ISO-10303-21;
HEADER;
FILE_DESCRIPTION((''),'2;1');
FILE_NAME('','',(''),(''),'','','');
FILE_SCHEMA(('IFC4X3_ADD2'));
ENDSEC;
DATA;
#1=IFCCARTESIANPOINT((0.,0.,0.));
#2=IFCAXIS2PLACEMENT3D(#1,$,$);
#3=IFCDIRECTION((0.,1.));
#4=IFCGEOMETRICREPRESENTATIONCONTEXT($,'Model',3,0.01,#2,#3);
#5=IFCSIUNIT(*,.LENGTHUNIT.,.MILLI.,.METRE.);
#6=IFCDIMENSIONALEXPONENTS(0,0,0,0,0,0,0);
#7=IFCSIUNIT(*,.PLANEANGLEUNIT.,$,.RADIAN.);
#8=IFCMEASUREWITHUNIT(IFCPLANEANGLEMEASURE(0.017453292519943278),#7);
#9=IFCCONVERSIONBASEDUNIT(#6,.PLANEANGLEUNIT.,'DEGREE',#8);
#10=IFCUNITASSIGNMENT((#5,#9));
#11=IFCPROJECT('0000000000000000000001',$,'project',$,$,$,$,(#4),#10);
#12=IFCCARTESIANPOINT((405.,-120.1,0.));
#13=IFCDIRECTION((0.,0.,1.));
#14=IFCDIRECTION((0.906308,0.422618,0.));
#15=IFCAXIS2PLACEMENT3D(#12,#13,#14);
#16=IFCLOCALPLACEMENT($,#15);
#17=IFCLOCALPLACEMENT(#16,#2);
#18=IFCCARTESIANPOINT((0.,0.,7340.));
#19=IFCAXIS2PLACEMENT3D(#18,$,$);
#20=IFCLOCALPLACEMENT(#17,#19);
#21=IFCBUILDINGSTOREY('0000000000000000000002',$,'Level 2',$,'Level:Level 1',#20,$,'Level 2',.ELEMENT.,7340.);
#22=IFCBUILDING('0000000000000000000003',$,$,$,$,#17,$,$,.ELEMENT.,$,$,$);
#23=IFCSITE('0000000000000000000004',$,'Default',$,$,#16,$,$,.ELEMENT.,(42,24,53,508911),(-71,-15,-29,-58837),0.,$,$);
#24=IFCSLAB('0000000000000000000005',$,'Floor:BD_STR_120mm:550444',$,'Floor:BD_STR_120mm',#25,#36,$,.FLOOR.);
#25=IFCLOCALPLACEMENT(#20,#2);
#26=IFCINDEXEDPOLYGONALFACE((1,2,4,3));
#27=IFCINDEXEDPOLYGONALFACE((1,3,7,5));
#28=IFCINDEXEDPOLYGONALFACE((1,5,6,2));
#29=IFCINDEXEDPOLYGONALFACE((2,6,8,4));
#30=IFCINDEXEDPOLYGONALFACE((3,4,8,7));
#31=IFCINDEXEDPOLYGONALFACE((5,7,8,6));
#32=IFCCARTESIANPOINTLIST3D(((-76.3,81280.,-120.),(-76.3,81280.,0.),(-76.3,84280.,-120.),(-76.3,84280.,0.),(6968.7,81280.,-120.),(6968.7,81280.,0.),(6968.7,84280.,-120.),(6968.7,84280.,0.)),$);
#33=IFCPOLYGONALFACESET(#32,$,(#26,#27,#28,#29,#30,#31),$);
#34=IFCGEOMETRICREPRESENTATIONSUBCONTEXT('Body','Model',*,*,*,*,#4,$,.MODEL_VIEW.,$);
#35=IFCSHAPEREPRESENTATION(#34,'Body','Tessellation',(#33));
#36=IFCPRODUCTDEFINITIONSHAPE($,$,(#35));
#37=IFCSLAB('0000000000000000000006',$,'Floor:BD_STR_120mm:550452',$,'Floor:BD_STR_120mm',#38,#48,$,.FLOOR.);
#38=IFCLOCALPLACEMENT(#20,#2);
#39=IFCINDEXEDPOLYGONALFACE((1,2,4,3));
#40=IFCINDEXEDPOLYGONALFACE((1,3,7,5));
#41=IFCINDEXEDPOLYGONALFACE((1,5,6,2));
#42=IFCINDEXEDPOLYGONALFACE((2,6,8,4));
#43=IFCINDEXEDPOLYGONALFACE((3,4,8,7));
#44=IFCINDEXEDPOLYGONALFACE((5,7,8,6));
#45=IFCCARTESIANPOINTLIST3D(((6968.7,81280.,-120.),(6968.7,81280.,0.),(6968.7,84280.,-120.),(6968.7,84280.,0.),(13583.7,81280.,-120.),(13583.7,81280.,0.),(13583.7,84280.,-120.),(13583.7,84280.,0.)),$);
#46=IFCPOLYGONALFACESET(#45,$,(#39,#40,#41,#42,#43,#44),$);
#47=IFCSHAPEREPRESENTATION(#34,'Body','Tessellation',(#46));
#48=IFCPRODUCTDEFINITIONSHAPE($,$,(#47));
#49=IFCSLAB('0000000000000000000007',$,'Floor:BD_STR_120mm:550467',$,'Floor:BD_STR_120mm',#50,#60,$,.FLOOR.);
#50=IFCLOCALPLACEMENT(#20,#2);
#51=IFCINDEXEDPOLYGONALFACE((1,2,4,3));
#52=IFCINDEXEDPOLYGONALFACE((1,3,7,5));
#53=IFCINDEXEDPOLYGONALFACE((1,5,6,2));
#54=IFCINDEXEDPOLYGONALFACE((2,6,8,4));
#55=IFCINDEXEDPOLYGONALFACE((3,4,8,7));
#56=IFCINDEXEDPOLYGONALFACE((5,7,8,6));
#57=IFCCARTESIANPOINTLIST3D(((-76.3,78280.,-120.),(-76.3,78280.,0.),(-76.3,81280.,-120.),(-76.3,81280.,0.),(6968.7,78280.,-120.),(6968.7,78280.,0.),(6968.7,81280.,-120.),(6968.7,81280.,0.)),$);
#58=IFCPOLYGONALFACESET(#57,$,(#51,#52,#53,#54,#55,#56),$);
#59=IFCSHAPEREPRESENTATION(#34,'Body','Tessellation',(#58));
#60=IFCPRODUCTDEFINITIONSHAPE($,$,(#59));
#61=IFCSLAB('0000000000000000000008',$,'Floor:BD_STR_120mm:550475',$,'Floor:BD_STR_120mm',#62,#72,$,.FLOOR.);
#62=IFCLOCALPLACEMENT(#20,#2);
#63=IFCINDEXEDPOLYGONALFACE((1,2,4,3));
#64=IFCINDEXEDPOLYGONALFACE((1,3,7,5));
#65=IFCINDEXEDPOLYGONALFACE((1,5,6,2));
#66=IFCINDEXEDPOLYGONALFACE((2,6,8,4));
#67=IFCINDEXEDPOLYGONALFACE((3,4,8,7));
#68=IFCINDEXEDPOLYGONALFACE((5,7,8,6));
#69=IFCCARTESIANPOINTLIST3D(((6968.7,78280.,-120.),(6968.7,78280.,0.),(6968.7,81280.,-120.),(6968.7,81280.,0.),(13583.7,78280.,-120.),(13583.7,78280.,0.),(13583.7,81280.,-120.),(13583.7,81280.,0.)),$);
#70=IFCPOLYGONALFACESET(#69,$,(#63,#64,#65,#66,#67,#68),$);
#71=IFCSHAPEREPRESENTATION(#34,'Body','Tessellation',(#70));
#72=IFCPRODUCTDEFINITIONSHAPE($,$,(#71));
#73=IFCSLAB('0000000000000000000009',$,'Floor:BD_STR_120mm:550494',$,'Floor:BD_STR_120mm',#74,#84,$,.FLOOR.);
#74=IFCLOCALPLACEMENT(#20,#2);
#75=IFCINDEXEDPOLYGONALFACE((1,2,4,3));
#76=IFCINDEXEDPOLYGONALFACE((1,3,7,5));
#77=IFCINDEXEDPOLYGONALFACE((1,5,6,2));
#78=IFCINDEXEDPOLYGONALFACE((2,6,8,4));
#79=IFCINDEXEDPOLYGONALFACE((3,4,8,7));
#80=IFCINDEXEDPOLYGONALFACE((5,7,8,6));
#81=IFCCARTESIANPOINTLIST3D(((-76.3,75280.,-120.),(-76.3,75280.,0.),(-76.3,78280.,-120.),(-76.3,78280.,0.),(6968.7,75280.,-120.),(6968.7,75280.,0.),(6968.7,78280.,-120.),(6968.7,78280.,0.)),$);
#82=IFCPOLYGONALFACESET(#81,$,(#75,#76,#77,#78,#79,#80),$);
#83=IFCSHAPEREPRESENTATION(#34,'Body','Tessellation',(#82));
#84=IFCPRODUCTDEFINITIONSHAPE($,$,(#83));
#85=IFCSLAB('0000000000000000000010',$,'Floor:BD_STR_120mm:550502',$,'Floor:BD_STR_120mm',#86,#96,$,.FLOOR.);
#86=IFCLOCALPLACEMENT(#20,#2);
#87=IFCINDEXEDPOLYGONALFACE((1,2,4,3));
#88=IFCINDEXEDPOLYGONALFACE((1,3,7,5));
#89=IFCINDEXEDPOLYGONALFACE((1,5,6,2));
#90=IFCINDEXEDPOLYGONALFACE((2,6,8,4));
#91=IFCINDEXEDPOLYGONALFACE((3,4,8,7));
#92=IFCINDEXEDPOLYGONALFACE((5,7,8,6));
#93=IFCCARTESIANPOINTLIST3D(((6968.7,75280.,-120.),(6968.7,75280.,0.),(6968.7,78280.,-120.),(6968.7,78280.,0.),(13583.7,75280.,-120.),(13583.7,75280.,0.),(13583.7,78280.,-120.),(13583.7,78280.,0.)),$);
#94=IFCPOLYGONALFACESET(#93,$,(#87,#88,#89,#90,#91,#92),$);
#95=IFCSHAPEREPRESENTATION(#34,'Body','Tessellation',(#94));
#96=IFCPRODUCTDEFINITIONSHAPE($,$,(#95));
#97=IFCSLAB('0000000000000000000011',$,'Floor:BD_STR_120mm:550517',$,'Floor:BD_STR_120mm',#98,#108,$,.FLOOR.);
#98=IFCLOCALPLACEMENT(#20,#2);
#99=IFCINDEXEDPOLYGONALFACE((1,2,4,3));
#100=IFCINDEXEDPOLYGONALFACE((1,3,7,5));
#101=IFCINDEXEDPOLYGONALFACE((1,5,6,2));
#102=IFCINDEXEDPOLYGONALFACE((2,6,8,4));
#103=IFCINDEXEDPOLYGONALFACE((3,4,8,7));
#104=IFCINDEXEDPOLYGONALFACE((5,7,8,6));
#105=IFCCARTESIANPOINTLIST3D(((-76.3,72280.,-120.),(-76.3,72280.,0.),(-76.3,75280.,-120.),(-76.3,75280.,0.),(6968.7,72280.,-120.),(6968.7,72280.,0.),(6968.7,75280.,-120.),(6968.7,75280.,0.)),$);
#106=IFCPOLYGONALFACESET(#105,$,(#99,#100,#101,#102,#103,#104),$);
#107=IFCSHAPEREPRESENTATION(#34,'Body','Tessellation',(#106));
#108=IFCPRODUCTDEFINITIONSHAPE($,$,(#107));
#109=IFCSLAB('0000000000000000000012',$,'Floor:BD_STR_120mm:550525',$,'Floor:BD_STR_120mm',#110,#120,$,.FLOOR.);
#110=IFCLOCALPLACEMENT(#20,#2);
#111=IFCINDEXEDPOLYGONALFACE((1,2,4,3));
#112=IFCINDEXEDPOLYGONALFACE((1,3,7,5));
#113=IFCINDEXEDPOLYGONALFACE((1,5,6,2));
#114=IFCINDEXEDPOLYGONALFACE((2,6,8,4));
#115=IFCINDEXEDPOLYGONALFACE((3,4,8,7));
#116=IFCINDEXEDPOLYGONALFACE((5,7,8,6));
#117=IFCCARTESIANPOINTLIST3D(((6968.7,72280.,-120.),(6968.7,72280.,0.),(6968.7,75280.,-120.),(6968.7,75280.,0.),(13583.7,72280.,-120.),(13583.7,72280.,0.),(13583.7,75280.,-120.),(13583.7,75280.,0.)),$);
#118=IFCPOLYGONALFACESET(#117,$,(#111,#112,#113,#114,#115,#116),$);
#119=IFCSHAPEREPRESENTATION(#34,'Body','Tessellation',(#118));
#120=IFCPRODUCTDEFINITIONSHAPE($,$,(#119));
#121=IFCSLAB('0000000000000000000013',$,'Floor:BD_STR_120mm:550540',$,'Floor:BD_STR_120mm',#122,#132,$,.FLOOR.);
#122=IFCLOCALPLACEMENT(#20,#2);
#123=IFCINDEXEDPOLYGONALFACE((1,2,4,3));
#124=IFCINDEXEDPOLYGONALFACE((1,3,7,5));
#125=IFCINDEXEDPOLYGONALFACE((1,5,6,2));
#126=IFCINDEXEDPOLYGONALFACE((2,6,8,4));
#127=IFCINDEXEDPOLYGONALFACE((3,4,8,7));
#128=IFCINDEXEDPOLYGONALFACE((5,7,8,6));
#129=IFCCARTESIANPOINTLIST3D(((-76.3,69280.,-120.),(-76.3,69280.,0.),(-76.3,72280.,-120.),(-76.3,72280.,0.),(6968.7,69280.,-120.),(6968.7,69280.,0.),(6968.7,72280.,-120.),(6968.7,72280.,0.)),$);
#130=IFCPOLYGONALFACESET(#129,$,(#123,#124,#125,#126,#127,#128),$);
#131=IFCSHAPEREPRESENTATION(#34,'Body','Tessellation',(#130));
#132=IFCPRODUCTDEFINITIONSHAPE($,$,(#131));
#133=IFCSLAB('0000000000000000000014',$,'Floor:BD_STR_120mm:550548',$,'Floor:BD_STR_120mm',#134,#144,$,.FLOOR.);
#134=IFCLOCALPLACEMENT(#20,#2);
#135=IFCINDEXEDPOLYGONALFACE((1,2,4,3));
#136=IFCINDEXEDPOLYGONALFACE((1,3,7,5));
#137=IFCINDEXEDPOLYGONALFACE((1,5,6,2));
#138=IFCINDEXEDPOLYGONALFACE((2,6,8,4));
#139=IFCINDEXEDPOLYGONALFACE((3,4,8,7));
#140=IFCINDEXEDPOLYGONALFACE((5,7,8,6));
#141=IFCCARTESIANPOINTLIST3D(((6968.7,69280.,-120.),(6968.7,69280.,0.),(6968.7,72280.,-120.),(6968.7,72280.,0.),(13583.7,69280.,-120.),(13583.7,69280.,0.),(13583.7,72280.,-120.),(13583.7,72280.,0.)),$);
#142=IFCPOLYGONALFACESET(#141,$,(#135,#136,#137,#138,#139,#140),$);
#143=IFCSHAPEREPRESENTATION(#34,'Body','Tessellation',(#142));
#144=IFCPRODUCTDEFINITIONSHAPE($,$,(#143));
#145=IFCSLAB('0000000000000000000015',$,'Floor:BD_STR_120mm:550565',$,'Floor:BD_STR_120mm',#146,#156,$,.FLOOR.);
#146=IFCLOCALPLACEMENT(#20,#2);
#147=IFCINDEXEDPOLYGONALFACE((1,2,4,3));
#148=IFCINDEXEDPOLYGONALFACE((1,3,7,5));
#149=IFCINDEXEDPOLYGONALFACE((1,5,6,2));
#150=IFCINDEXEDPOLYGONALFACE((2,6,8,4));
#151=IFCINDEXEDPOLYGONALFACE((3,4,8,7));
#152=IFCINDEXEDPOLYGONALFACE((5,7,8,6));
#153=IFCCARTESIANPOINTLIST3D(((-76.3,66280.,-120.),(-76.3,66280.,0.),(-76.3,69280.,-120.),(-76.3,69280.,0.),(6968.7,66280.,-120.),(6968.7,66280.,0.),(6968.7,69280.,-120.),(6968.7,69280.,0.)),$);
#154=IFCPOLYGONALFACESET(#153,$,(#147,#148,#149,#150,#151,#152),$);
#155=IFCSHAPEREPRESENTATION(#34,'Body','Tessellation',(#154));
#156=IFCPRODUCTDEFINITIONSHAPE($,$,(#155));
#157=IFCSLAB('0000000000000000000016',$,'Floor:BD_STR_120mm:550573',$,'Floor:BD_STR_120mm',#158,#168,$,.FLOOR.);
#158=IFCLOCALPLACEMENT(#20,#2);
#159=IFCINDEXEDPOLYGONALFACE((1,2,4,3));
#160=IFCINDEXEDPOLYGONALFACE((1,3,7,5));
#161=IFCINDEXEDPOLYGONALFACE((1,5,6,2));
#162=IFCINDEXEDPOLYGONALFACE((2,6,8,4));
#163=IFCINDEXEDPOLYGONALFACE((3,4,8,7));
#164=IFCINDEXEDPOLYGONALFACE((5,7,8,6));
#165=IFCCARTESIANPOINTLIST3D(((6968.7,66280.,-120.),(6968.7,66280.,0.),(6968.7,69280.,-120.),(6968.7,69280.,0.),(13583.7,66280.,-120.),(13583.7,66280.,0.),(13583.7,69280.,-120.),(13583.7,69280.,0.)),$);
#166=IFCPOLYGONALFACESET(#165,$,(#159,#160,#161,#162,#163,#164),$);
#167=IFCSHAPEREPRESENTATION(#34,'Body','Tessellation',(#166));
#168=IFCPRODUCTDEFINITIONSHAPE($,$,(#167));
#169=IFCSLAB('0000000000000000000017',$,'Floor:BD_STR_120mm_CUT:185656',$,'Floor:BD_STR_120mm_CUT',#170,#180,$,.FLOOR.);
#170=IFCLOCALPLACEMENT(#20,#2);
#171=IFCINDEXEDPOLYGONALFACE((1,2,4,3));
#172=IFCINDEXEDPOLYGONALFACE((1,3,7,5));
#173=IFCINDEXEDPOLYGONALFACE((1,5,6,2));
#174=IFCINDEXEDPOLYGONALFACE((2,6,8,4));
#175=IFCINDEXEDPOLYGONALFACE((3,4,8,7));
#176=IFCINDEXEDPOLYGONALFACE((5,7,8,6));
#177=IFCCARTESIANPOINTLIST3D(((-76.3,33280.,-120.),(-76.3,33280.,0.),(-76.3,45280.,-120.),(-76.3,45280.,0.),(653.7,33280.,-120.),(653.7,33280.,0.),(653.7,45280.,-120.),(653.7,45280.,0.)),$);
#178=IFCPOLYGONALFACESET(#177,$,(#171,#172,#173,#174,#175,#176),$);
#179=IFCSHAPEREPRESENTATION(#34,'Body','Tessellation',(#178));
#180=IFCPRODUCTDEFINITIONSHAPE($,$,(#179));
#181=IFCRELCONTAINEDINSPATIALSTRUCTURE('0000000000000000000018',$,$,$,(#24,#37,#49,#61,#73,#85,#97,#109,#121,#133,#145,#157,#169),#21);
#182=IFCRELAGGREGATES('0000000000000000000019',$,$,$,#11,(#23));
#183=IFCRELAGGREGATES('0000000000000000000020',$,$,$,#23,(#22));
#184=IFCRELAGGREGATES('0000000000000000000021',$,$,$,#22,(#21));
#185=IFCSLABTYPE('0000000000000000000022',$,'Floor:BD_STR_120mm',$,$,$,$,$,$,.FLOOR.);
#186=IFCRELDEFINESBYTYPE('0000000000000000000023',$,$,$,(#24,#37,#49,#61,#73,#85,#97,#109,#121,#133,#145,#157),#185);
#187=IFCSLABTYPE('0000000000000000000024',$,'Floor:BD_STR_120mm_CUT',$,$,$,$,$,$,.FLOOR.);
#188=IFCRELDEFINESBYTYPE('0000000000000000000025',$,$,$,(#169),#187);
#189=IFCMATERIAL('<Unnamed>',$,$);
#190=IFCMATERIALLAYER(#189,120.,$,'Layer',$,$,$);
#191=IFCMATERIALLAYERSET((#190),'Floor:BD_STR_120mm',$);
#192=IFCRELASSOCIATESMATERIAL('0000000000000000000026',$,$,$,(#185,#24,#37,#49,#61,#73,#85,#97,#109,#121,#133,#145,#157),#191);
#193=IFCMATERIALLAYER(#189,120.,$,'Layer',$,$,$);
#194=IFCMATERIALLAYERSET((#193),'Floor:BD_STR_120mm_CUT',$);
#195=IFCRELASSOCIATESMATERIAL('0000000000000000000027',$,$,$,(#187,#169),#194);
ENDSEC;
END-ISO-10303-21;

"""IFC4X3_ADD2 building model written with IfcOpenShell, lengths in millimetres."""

from ifc_helpers import new_model, entity, si_unit, converted_unit, direction, frame, frame_2d, origin, origin_2d_with_axis, place, context, subcontext, project, spatial, rectangle, extrude, material, layer, layer_set, layer_usage, type_object, element, save


model = new_model("IFC4X3_ADD2")

# Units and contexts
model_context = context("Model", 3, precision=0.01, world=origin(), true_north=direction((0.0, 1.0)))
body_context = subcontext(model_context, "Body", "Model", "MODEL_VIEW")
ifc_project = project(units=[si_unit("LENGTHUNIT", "METRE", prefix="MILLI"), converted_unit("PLANEANGLEUNIT", "DEGREE", entity("IfcPlaneAngleMeasure", 0.017453292519943278), si_unit("PLANEANGLEUNIT", "RADIAN"), dimensions=[0, 0, 0, 0, 0, 0, 0])], contexts=[model_context])

# Site, building, storey
site_placement = place(None, frame((405.0, -120.1, 0.0), z_axis=(0.0, 0.0, 1.0), x_axis=(0.906308, 0.422618, 0.0)))
site = spatial("IfcSite", under=ifc_project, at=site_placement, Name="Default", CompositionType="ELEMENT", RefLatitude=(42, 24, 53, 508911), RefLongitude=(-71, -15, -29, -58837), RefElevation=0.0)
building_placement = place(site_placement, origin())
building = spatial("IfcBuilding", under=site, at=building_placement, CompositionType="ELEMENT")
storey_placement = place(building_placement, frame((0.0, 0.0, 7340.0)))
storey = spatial("IfcBuildingStorey", under=building, at=storey_placement, Name="Level 2", ObjectType="Level:Level 1", LongName="Level 2", CompositionType="ELEMENT", Elevation=7340.0)

# Slabs
ifc_material_1 = material(Name="<Unnamed>")
ifc_layer_1 = layer(ifc_material_1, 120.0, Name="Layer")
ifc_layer_set_1 = layer_set([ifc_layer_1], Name="Floor:BD_STR_120mm")
slab_type_1 = type_object("IfcSlabType", Name="Floor:BD_STR_120mm", PredefinedType="FLOOR", material=ifc_layer_set_1)
ifc_layer_usage_1 = layer_usage(ifc_layer_set_1, "AXIS3", "POSITIVE", 0.0)
slab_1_placement = place(storey_placement, origin())
element("IfcSlab", 1, at=slab_1_placement, inside=storey, type_object=slab_type_1, material=ifc_layer_usage_1, Name="Floor:BD_STR_120mm:550444", ObjectType="Floor:BD_STR_120mm", PredefinedType="FLOOR", context=body_context, shape_type="SweptSolid", body=[
    extrude(rectangle(XDim=3000.0, YDim=7045.0, at=origin_2d_with_axis()), frame((3446.2, 82780.0, 0.0), z_axis=(0.0, 0.0, -1.0), x_axis=(0.0, 1.0, 0.0)), (0.0, 0.0, 1.0), 120.0),
])
ifc_layer_usage_2 = layer_usage(ifc_layer_set_1, "AXIS3", "POSITIVE", 0.0)
slab_2_placement = place(storey_placement, origin())
element("IfcSlab", 2, at=slab_2_placement, inside=storey, type_object=slab_type_1, material=ifc_layer_usage_2, Name="Floor:BD_STR_120mm:550452", ObjectType="Floor:BD_STR_120mm", PredefinedType="FLOOR", context=body_context, shape_type="SweptSolid", body=[
    extrude(rectangle(XDim=3000.0, YDim=6615.0, at=frame_2d((0.0, 0.0), x_axis=(1.0, 0.0))), frame((10276.2, 82780.0, 0.0), z_axis=(0.0, 0.0, -1.0), x_axis=(0.0, 1.0, 0.0)), (0.0, 0.0, 1.0), 120.0),
])
ifc_layer_usage_3 = layer_usage(ifc_layer_set_1, "AXIS3", "POSITIVE", 0.0)
slab_3_placement = place(storey_placement, origin())
element("IfcSlab", 3, at=slab_3_placement, inside=storey, type_object=slab_type_1, material=ifc_layer_usage_3, Name="Floor:BD_STR_120mm:550467", ObjectType="Floor:BD_STR_120mm", PredefinedType="FLOOR", context=body_context, shape_type="SweptSolid", body=[
    extrude(rectangle(XDim=3000.0, YDim=7045.0, at=origin_2d_with_axis()), frame((3446.2, 79780.0, 0.0), z_axis=(0.0, 0.0, -1.0), x_axis=(0.0, 1.0, 0.0)), (0.0, 0.0, 1.0), 120.0),
])
ifc_layer_usage_4 = layer_usage(ifc_layer_set_1, "AXIS3", "POSITIVE", 0.0)
slab_4_placement = place(storey_placement, origin())
element("IfcSlab", 4, at=slab_4_placement, inside=storey, type_object=slab_type_1, material=ifc_layer_usage_4, Name="Floor:BD_STR_120mm:550475", ObjectType="Floor:BD_STR_120mm", PredefinedType="FLOOR", context=body_context, shape_type="SweptSolid", body=[
    extrude(rectangle(XDim=3000.0, YDim=6615.0, at=frame_2d((0.0, 0.0), x_axis=(1.0, 0.0))), frame((10276.2, 79780.0, 0.0), z_axis=(0.0, 0.0, -1.0), x_axis=(0.0, 1.0, 0.0)), (0.0, 0.0, 1.0), 120.0),
])
ifc_layer_usage_5 = layer_usage(ifc_layer_set_1, "AXIS3", "POSITIVE", 0.0)
slab_5_placement = place(storey_placement, origin())
element("IfcSlab", 5, at=slab_5_placement, inside=storey, type_object=slab_type_1, material=ifc_layer_usage_5, Name="Floor:BD_STR_120mm:550494", ObjectType="Floor:BD_STR_120mm", PredefinedType="FLOOR", context=body_context, shape_type="SweptSolid", body=[
    extrude(rectangle(XDim=3000.0, YDim=7045.0, at=frame_2d((0.0, 0.0), x_axis=(1.0, 0.0))), frame((3446.2, 76780.0, 0.0), z_axis=(0.0, 0.0, -1.0), x_axis=(0.0, 1.0, 0.0)), (0.0, 0.0, 1.0), 120.0),
])
ifc_layer_usage_6 = layer_usage(ifc_layer_set_1, "AXIS3", "POSITIVE", 0.0)
slab_6_placement = place(storey_placement, origin())
element("IfcSlab", 6, at=slab_6_placement, inside=storey, type_object=slab_type_1, material=ifc_layer_usage_6, Name="Floor:BD_STR_120mm:550502", ObjectType="Floor:BD_STR_120mm", PredefinedType="FLOOR", context=body_context, shape_type="SweptSolid", body=[
    extrude(rectangle(XDim=3000.0, YDim=6615.0, at=frame_2d((0.0, 0.0), x_axis=(1.0, 0.0))), frame((10276.2, 76780.0, 0.0), z_axis=(0.0, 0.0, -1.0), x_axis=(0.0, 1.0, 0.0)), (0.0, 0.0, 1.0), 120.0),
])
ifc_layer_usage_7 = layer_usage(ifc_layer_set_1, "AXIS3", "POSITIVE", 0.0)
slab_7_placement = place(storey_placement, origin())
element("IfcSlab", 7, at=slab_7_placement, inside=storey, type_object=slab_type_1, material=ifc_layer_usage_7, Name="Floor:BD_STR_120mm:550517", ObjectType="Floor:BD_STR_120mm", PredefinedType="FLOOR", context=body_context, shape_type="SweptSolid", body=[
    extrude(rectangle(XDim=3000.0, YDim=7045.0, at=frame_2d((0.0, 0.0), x_axis=(1.0, 0.0))), frame((3446.2, 73780.0, 0.0), z_axis=(0.0, 0.0, -1.0), x_axis=(0.0, 1.0, 0.0)), (0.0, 0.0, 1.0), 120.0),
])
ifc_layer_usage_8 = layer_usage(ifc_layer_set_1, "AXIS3", "POSITIVE", 0.0)
slab_8_placement = place(storey_placement, origin())
element("IfcSlab", 8, at=slab_8_placement, inside=storey, type_object=slab_type_1, material=ifc_layer_usage_8, Name="Floor:BD_STR_120mm:550525", ObjectType="Floor:BD_STR_120mm", PredefinedType="FLOOR", context=body_context, shape_type="SweptSolid", body=[
    extrude(rectangle(XDim=3000.0, YDim=6615.0, at=frame_2d((0.0, 0.0), x_axis=(1.0, 0.0))), frame((10276.2, 73780.0, 0.0), z_axis=(0.0, 0.0, -1.0), x_axis=(0.0, 1.0, 0.0)), (0.0, 0.0, 1.0), 120.0),
])
ifc_layer_usage_9 = layer_usage(ifc_layer_set_1, "AXIS3", "POSITIVE", 0.0)
slab_9_placement = place(storey_placement, origin())
element("IfcSlab", 9, at=slab_9_placement, inside=storey, type_object=slab_type_1, material=ifc_layer_usage_9, Name="Floor:BD_STR_120mm:550540", ObjectType="Floor:BD_STR_120mm", PredefinedType="FLOOR", context=body_context, shape_type="SweptSolid", body=[
    extrude(rectangle(XDim=3000.0, YDim=7045.0, at=frame_2d((0.0, 0.0), x_axis=(1.0, 0.0))), frame((3446.2, 70780.0, 0.0), z_axis=(0.0, 0.0, -1.0), x_axis=(0.0, 1.0, 0.0)), (0.0, 0.0, 1.0), 120.0),
])
ifc_layer_usage_10 = layer_usage(ifc_layer_set_1, "AXIS3", "POSITIVE", 0.0)
slab_10_placement = place(storey_placement, origin())
element("IfcSlab", 10, at=slab_10_placement, inside=storey, type_object=slab_type_1, material=ifc_layer_usage_10, Name="Floor:BD_STR_120mm:550548", ObjectType="Floor:BD_STR_120mm", PredefinedType="FLOOR", context=body_context, shape_type="SweptSolid", body=[
    extrude(rectangle(XDim=3000.0, YDim=6615.0, at=frame_2d((0.0, 0.0), x_axis=(1.0, 0.0))), frame((10276.2, 70780.0, 0.0), z_axis=(0.0, 0.0, -1.0), x_axis=(0.0, 1.0, 0.0)), (0.0, 0.0, 1.0), 120.0),
])
ifc_layer_usage_11 = layer_usage(ifc_layer_set_1, "AXIS3", "POSITIVE", 0.0)
slab_11_placement = place(storey_placement, origin())
element("IfcSlab", 11, at=slab_11_placement, inside=storey, type_object=slab_type_1, material=ifc_layer_usage_11, Name="Floor:BD_STR_120mm:550565", ObjectType="Floor:BD_STR_120mm", PredefinedType="FLOOR", context=body_context, shape_type="SweptSolid", body=[
    extrude(rectangle(XDim=3000.0, YDim=7045.0, at=frame_2d((0.0, 0.0), x_axis=(1.0, 0.0))), frame((3446.2, 67780.0, 0.0), z_axis=(0.0, 0.0, -1.0), x_axis=(0.0, 1.0, 0.0)), (0.0, 0.0, 1.0), 120.0),
])
ifc_layer_usage_12 = layer_usage(ifc_layer_set_1, "AXIS3", "POSITIVE", 0.0)
slab_12_placement = place(storey_placement, origin())
element("IfcSlab", 12, at=slab_12_placement, inside=storey, type_object=slab_type_1, material=ifc_layer_usage_12, Name="Floor:BD_STR_120mm:550573", ObjectType="Floor:BD_STR_120mm", PredefinedType="FLOOR", context=body_context, shape_type="SweptSolid", body=[
    extrude(rectangle(XDim=3000.0, YDim=6615.0, at=frame_2d((0.0, 0.0), x_axis=(1.0, 0.0))), frame((10276.2, 67780.0, 0.0), z_axis=(0.0, 0.0, -1.0), x_axis=(0.0, 1.0, 0.0)), (0.0, 0.0, 1.0), 120.0),
])
ifc_layer_2 = layer(ifc_material_1, 120.0, Name="Layer")
ifc_layer_set_2 = layer_set([ifc_layer_2], Name="Floor:BD_STR_120mm_CUT")
ifc_layer_usage_13 = layer_usage(ifc_layer_set_2, "AXIS3", "POSITIVE", 0.0)
slab_type_2 = type_object("IfcSlabType", Name="Floor:BD_STR_120mm_CUT", PredefinedType="FLOOR", material=ifc_layer_set_2)
slab_13_placement = place(storey_placement, origin())
element("IfcSlab", 13, at=slab_13_placement, inside=storey, type_object=slab_type_2, material=ifc_layer_usage_13, Name="Floor:BD_STR_120mm_CUT:185656", ObjectType="Floor:BD_STR_120mm_CUT", PredefinedType="FLOOR", context=body_context, shape_type="SweptSolid", body=[
    extrude(rectangle(XDim=12000.0, YDim=730.0, at=frame_2d((0.0, 0.0), x_axis=(1.0, 0.0))), frame((288.7, 39280.0, 0.0), z_axis=(0.0, 0.0, -1.0), x_axis=(0.0, 1.0, 0.0)), (0.0, 0.0, 1.0), 120.0),
])

save(model, "model.ifc")
